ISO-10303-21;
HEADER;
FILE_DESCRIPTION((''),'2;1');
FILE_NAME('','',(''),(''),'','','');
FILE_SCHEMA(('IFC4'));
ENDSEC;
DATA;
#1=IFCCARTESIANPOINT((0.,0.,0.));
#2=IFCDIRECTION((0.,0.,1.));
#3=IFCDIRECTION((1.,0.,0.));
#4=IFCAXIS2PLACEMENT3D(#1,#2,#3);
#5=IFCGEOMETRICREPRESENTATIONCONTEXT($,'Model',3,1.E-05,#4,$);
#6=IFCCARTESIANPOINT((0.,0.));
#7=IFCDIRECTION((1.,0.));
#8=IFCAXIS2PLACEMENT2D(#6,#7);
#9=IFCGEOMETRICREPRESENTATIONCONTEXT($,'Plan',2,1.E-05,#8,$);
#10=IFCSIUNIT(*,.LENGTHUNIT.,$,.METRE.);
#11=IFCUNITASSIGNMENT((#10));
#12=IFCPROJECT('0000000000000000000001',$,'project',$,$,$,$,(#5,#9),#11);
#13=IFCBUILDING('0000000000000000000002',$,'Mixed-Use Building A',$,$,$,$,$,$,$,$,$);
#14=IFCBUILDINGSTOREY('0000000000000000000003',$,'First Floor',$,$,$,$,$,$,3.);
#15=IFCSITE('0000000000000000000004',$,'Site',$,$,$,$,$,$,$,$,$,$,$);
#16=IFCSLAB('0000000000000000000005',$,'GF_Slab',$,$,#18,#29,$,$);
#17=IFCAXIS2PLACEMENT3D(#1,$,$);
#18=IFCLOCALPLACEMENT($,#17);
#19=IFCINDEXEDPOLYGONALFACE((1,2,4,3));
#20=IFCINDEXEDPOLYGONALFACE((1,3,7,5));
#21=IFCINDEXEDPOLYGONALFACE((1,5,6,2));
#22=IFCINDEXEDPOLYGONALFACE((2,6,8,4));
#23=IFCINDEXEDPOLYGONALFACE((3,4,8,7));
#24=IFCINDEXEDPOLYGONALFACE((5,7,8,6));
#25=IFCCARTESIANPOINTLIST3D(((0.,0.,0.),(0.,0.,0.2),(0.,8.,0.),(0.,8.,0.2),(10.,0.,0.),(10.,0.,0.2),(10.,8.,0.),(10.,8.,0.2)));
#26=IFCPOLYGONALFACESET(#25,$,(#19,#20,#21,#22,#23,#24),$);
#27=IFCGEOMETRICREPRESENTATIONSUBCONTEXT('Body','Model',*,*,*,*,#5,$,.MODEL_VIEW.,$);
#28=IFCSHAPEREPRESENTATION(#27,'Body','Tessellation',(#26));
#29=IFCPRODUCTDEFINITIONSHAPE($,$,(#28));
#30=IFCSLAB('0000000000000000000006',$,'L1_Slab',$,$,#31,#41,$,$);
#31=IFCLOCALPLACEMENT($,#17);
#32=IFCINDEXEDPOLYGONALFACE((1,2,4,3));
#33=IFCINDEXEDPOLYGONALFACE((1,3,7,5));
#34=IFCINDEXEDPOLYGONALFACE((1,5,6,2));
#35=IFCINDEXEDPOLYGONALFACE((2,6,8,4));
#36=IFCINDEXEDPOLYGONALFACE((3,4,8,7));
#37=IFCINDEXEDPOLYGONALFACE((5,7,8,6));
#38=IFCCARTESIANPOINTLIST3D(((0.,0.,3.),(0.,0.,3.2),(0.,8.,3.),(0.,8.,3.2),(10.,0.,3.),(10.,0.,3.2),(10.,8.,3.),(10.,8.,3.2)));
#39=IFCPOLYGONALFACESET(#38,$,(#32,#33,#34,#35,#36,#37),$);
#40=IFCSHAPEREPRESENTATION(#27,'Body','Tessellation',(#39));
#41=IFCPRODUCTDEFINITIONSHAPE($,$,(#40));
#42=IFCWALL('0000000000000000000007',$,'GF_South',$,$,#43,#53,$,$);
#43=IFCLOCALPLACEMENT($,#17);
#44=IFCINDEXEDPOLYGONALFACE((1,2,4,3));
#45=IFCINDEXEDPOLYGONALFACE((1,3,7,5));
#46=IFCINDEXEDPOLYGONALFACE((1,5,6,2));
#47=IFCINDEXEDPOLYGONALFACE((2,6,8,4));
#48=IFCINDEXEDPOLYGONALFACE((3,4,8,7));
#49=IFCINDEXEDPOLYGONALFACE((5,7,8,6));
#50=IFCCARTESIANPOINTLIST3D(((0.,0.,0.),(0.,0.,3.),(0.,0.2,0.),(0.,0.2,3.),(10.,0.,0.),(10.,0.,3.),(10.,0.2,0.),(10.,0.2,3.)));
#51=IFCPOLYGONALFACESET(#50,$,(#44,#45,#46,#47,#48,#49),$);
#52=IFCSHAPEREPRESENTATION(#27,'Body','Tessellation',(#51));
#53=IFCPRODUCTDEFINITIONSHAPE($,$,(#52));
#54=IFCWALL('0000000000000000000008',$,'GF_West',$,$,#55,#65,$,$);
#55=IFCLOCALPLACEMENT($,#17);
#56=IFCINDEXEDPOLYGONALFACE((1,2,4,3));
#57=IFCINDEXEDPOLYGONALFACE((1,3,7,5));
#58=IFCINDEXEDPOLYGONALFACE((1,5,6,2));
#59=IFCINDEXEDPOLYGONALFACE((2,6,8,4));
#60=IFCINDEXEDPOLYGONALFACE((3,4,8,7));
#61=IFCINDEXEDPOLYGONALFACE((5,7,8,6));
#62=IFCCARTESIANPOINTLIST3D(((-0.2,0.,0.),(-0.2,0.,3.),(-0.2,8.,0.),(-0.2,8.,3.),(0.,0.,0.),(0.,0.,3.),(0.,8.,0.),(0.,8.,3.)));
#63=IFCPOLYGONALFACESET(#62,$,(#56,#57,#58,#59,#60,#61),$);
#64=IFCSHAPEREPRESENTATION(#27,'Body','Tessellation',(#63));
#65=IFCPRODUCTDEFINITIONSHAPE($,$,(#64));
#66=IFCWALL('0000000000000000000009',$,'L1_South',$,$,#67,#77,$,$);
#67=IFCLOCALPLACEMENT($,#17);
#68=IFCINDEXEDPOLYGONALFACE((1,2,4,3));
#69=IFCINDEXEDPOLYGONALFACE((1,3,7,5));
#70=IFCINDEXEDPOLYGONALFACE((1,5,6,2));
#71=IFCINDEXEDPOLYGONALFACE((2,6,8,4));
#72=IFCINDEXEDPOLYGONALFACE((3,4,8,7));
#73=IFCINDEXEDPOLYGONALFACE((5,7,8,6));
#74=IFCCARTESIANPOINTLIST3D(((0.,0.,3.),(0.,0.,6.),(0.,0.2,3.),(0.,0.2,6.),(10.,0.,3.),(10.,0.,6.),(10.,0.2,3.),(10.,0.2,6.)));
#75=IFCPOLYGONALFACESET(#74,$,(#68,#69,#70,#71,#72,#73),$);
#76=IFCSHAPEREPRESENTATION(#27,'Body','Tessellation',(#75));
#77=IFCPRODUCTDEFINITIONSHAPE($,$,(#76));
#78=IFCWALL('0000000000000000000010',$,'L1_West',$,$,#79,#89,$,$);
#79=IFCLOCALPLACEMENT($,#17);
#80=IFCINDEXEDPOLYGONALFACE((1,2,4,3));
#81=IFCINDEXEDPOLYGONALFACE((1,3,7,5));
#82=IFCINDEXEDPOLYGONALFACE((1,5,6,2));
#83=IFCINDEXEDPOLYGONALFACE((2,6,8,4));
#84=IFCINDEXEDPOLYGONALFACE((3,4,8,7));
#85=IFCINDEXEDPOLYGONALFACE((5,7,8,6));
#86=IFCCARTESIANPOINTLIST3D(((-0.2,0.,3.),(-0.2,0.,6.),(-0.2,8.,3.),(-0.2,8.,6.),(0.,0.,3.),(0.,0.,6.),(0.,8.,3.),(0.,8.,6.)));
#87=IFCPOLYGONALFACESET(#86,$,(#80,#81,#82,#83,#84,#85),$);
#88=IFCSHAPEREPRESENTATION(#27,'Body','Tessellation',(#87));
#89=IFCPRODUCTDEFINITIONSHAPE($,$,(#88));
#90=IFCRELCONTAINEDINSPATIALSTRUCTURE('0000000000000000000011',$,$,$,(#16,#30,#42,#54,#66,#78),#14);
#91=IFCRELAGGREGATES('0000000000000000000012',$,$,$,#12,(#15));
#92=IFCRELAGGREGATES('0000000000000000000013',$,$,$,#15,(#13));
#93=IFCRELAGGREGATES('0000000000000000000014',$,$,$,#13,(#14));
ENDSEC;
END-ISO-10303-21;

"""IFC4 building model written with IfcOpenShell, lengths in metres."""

from ifc_helpers import new_model, si_unit, frame, origin_with_axes, origin_2d_with_axis, place, context, subcontext, project, spatial, indexed_curve, outline, extrude, element, save


model = new_model("IFC4")

# Units and contexts
model_context = context("Model", 3, precision=1e-05, world=origin_with_axes())
plan_context = context("Plan", 2, precision=1e-05, world=origin_2d_with_axis())
body_context = subcontext(model_context, "Body", "Model", "MODEL_VIEW")
ifc_project = project(units=[si_unit("LENGTHUNIT", "METRE")], contexts=[model_context, plan_context])

# Site, building, storey
site = spatial("IfcSite", under=ifc_project, Name="Site")
building = spatial("IfcBuilding", under=site, Name="Mixed-Use Building A")
storey = spatial("IfcBuildingStorey", under=building, Name="First Floor", Elevation=3.0)

# Slabs
for number, where, z_axis, x_axis, name in (
    (1, (0.0, 0.0, 0.0), (0.0, 0.0, 1.0), (1.0, 0.0, 0.0), "GF_Slab"),
    (2, (0.0, 0.0, 3.0), (0.0, 0.0, 1.0), (1.0, 0.0, 0.0), "L1_Slab"),
):
    element("IfcSlab", number, at=place(None, frame(where, z_axis=z_axis, x_axis=x_axis)), inside=storey, Name=name, context=body_context, shape_type="SweptSolid", body=[
        extrude(outline(indexed_curve([(0.0, 0.0), (10.0, 0.0), (10.0, 8.0), (0.0, 8.0)])), None, (0.0, 0.0, 1.0), 0.2),
    ])

# Walls
wall_1_placement = place(None, origin_with_axes())
element("IfcWall", 3, at=wall_1_placement, inside=storey, Name="GF_South", context=body_context, shape_type="SweptSolid", body=[
    extrude(outline(indexed_curve([(0.0, 0.0), (0.0, 0.2), (10.0, 0.2), (10.0, 0.0), (0.0, 0.0)], self_intersect=False)), origin_with_axes(), (0.0, 0.0, 1.0), 3.0),
])
wall_2_placement = place(None, frame((0.0, 0.0, 0.0), z_axis=(0.0, 0.0, 1.0), x_axis=(0.0, 1.0, 0.0)))
element("IfcWall", 4, at=wall_2_placement, inside=storey, Name="GF_West", context=body_context, shape_type="SweptSolid", body=[
    extrude(outline(indexed_curve([(0.0, 0.0), (0.0, 0.2), (8.0, 0.2), (8.0, 0.0), (0.0, 0.0)], self_intersect=False)), origin_with_axes(), (0.0, 0.0, 1.0), 3.0),
])
wall_3_placement = place(None, frame((0.0, 0.0, 3.0), z_axis=(0.0, 0.0, 1.0), x_axis=(1.0, 0.0, 0.0)))
element("IfcWall", 5, at=wall_3_placement, inside=storey, Name="L1_South", context=body_context, shape_type="SweptSolid", body=[
    extrude(outline(indexed_curve([(0.0, 0.0), (0.0, 0.2), (10.0, 0.2), (10.0, 0.0), (0.0, 0.0)], self_intersect=False)), origin_with_axes(), (0.0, 0.0, 1.0), 3.0),
])
wall_4_placement = place(None, frame((0.0, 0.0, 3.0), z_axis=(0.0, 0.0, 1.0), x_axis=(0.0, 1.0, 0.0)))
element("IfcWall", 6, at=wall_4_placement, inside=storey, Name="L1_West", context=body_context, shape_type="SweptSolid", body=[
    extrude(outline(indexed_curve([(0.0, 0.0), (0.0, 0.2), (8.0, 0.2), (8.0, 0.0), (0.0, 0.0)], self_intersect=False)), origin_with_axes(), (0.0, 0.0, 1.0), 3.0),
])

save(model, "model.ifc")
